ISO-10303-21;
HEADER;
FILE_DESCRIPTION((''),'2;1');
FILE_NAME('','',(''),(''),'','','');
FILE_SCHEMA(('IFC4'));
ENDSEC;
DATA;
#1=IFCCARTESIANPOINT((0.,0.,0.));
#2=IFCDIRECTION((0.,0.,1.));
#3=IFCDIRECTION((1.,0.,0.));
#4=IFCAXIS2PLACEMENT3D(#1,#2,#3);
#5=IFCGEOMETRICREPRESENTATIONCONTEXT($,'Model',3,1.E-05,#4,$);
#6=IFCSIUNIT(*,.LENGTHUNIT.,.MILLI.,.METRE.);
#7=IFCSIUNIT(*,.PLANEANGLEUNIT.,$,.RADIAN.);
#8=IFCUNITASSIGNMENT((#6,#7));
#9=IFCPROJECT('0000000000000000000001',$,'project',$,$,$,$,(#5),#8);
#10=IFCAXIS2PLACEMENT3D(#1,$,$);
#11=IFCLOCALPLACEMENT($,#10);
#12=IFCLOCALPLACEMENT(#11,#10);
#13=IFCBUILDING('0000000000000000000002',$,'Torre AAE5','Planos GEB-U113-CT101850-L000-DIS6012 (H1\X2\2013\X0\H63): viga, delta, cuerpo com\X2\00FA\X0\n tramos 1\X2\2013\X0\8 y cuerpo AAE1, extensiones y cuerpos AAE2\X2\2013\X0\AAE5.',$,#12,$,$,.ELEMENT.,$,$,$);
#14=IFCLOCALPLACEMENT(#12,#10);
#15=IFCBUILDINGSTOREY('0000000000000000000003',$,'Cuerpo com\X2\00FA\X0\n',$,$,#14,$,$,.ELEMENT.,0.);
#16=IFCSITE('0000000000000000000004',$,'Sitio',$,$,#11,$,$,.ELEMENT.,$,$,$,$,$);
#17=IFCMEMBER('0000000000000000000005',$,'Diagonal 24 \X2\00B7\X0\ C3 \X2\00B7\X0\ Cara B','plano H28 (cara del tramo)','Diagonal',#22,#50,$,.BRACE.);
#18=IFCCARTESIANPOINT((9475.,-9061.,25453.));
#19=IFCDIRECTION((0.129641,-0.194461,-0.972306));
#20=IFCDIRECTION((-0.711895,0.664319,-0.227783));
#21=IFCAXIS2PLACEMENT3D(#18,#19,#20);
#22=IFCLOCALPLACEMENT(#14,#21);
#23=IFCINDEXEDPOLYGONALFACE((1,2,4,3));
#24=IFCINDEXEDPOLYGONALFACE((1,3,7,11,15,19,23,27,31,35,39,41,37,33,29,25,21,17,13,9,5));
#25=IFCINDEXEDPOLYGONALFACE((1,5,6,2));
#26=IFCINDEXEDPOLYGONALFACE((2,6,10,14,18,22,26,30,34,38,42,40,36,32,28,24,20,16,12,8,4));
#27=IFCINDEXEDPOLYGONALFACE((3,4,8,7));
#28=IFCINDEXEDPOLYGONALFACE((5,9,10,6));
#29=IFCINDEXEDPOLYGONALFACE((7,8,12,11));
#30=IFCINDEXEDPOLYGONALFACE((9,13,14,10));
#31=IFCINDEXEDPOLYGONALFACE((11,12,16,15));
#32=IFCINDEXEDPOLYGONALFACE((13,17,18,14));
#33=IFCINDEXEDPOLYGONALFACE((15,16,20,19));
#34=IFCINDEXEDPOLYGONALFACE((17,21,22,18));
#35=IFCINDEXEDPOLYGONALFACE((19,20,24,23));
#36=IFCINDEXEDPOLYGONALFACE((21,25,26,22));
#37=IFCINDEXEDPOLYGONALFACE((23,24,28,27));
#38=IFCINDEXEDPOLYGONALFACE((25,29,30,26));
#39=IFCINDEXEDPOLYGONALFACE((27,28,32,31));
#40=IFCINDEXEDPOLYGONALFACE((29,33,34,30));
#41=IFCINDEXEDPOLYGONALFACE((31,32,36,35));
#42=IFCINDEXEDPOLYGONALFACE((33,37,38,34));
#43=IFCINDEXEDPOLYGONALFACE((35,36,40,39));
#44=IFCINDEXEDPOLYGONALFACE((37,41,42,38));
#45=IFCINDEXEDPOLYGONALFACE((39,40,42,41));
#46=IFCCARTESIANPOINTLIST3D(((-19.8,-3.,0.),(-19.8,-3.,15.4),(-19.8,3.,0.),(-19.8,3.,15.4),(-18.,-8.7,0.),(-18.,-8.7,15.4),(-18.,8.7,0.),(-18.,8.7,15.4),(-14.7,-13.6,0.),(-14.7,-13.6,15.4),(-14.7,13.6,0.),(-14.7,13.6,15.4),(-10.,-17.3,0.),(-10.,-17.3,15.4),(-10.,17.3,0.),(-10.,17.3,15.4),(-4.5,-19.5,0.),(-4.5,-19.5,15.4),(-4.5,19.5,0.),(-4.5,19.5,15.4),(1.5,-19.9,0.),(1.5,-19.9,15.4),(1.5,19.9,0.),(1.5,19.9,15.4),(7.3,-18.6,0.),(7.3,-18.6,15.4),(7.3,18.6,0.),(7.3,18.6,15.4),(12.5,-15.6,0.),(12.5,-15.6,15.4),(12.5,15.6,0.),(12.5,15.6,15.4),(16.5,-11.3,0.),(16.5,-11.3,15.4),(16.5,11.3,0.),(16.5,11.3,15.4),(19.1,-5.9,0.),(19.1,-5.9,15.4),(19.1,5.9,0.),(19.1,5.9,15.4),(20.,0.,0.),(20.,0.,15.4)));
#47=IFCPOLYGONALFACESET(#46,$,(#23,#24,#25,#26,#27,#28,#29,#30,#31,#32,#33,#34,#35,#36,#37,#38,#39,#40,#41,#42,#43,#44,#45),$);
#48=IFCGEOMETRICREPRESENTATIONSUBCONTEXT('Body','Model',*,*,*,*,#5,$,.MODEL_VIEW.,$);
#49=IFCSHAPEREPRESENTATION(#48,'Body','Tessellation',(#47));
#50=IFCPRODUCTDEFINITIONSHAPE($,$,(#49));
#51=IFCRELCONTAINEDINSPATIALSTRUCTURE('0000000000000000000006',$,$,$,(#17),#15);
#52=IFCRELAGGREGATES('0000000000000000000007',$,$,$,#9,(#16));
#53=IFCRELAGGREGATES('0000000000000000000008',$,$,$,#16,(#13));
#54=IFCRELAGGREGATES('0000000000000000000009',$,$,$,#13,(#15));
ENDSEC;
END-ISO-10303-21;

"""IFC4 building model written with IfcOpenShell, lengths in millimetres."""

from ifc_helpers import new_model, si_unit, frame, origin, origin_with_axes, place, context, subcontext, project, spatial, circle, extrude, element, save


model = new_model("IFC4")

# Units and contexts
model_context = context("Model", 3, precision=1e-05, world=origin_with_axes())
body_context = subcontext(model_context, "Body", "Model", "MODEL_VIEW")
ifc_project = project(units=[si_unit("LENGTHUNIT", "METRE", prefix="MILLI"), si_unit("PLANEANGLEUNIT", "RADIAN")], contexts=[model_context])

# Site, building, storey
site_placement = place(None, origin())
site = spatial("IfcSite", under=ifc_project, at=site_placement, Name="Sitio", CompositionType="ELEMENT")
building_placement = place(site_placement, origin())
building = spatial("IfcBuilding", under=site, at=building_placement, Name="Torre AAE5", Description="Planos GEB-U113-CT101850-L000-DIS6012 (H1–H63): viga, delta, cuerpo común tramos 1–8 y cuerpo AAE1, extensiones y cuerpos AAE2–AAE5.", CompositionType="ELEMENT")
storey_placement = place(building_placement, origin())
storey = spatial("IfcBuildingStorey", under=building, at=storey_placement, Name="Cuerpo común", CompositionType="ELEMENT", Elevation=0.0)

# Member
member_1_placement = place(storey_placement, frame((9475.0, -9061.0, 25453.0), z_axis=(0.129641, -0.194461, -0.972306), x_axis=(-0.711895, 0.664319, -0.227783)))
element("IfcMember", 1, at=member_1_placement, inside=storey, Name="Diagonal 24 · C3 · Cara B", Description="plano H28 (cara del tramo)", ObjectType="Diagonal", PredefinedType="BRACE", context=body_context, shape_type="SweptSolid", body=[
    extrude(circle(Radius=20.0), None, (0.0, 0.0, 1.0), 15.4),
])

save(model, "model.ifc")
